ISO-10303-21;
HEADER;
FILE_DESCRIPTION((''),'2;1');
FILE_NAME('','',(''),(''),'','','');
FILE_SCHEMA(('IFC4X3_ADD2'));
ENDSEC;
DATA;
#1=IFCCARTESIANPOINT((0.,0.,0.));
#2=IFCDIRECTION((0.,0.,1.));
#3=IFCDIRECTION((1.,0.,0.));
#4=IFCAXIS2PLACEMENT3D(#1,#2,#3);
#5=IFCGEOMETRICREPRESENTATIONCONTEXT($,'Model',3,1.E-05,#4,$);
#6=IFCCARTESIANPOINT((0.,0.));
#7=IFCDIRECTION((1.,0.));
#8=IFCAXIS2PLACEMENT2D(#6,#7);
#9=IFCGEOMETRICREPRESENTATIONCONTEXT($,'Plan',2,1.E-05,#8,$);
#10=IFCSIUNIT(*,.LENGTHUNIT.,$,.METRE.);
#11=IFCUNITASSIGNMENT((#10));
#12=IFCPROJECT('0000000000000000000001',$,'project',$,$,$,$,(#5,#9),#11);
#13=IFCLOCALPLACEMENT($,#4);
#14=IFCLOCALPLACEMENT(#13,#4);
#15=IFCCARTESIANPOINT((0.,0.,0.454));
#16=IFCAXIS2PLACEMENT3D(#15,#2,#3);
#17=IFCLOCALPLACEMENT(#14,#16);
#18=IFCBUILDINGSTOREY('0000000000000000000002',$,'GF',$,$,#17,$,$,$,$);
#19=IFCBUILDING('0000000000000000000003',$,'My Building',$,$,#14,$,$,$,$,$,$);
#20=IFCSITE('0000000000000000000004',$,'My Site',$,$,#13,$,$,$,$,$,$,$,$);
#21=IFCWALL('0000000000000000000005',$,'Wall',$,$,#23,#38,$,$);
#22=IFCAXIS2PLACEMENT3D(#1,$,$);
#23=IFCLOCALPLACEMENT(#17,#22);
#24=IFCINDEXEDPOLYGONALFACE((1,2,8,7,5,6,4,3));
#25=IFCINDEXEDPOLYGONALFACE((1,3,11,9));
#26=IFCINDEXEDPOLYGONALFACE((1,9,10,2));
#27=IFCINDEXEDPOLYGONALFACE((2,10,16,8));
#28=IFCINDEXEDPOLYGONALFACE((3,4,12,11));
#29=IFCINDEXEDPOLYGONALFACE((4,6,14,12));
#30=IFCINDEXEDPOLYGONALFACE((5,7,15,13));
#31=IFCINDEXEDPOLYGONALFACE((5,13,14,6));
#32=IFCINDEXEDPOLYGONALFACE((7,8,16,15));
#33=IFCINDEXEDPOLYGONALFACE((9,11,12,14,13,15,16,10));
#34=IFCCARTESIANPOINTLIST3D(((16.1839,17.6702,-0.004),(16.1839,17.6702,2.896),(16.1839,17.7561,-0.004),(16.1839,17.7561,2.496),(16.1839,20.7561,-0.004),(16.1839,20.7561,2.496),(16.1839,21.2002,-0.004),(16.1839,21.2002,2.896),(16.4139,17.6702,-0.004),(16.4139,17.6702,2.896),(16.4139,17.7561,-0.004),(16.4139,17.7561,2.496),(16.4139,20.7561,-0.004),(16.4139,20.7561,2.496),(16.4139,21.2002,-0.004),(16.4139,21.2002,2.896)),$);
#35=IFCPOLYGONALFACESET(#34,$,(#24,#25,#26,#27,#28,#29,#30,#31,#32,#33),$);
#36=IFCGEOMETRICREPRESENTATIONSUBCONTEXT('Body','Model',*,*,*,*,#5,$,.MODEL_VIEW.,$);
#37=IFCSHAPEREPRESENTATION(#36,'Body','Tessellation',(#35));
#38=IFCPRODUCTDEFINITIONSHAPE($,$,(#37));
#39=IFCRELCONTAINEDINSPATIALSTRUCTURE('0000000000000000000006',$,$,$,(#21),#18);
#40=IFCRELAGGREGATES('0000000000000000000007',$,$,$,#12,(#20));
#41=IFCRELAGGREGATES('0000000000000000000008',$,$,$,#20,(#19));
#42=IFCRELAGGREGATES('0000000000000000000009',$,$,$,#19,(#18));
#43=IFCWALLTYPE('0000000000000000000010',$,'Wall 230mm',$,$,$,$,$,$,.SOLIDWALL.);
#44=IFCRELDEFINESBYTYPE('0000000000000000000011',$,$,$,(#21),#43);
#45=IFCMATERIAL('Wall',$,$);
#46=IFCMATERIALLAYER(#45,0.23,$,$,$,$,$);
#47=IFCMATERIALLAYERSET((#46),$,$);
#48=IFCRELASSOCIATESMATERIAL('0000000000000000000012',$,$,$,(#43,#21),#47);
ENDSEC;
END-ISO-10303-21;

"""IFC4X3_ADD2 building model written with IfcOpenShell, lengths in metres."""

from ifc_helpers import new_model, si_unit, frame, origin_with_axes, origin_2d_with_axis, place, context, subcontext, project, spatial, line, indexed_curve, outline, extrude, source, transform, mapped, material, layer, layer_set, layer_usage, type_object, element, save


model = new_model("IFC4X3_ADD2")

# Units and contexts
model_context = context("Model", 3, precision=1e-05, world=origin_with_axes())
plan_context = context("Plan", 2, precision=1e-05, world=origin_2d_with_axis())
body_context = subcontext(model_context, "Body", "Model", "MODEL_VIEW")
ifc_project = project(units=[si_unit("LENGTHUNIT", "METRE")], contexts=[model_context, plan_context])

# Site, building, storey
site_placement = place(None, origin_with_axes())
site = spatial("IfcSite", under=ifc_project, at=site_placement, Name="My Site")
building_placement = place(site_placement, origin_with_axes())
building = spatial("IfcBuilding", under=site, at=building_placement, Name="My Building")
storey_placement = place(building_placement, frame((0.0, 0.0, 0.454), z_axis=(0.0, 0.0, 1.0), x_axis=(1.0, 0.0, 0.0)))
storey = spatial("IfcBuildingStorey", under=building, at=storey_placement, Name="GF")

# Wall, opening
ifc_material_1 = material(Name="Wall")
ifc_layer_1 = layer(ifc_material_1, 0.23)
ifc_layer_set_1 = layer_set([ifc_layer_1])
ifc_layer_usage_1 = layer_usage(ifc_layer_set_1, "AXIS2", "POSITIVE", 0.0)
wall_type = type_object("IfcWallType", Name="Wall 230mm", PredefinedType="SOLIDWALL", material=ifc_layer_set_1)
wall_placement = place(storey_placement, frame((16.4139, 17.6702, -0.004), z_axis=(0.0, 0.0, 1.0), x_axis=(0.000001, 1.0, 0.0)))
wall = element("IfcWall", 1, at=wall_placement, inside=storey, type_object=wall_type, material=ifc_layer_usage_1, Name="Wall", context=body_context, shape_type="SweptSolid", body=[
    extrude(outline(indexed_curve([(0.0, 0.0), (0.0, 0.23), (3.53, 0.23), (3.53, 0.0), (0.0, 0.0)], self_intersect=False)), origin_with_axes(), (0.0, 0.0, 1.0), 2.9),
])
shared_shape = source(origin_with_axes(), body_context, "Body", "SweptSolid", [
    extrude(outline(indexed_curve([(0.0, 0.0), (3.0, 0.0), (3.0, 2.5), (0.0, 2.5)], segments=[line(1, 2, 3, 4, 1)])), frame((0.0, -0.6, 0.0), z_axis=(0.0, -1.0, 0.0), x_axis=(1.0, 0.0, 0.0)), (0.0, 0.0, -1.0), 1.2),
])
opening_placement = place(wall_placement, frame((0.0859, 0.0, 0.0), z_axis=(0.0, 0.0, 1.0), x_axis=(1.0, 0.0, 0.0)))
element("IfcOpeningElement", 2, at=opening_placement, cuts=wall, PredefinedType="OPENING", context=body_context, shape_type="MappedRepresentation", body=[
    mapped(shared_shape, transform((0.0, 0.0, 0.0), x_axis=(1.0, 0.0, 0.0), y_axis=(0.0, 1.0, 0.0), z_axis=(0.0, 0.0, 1.0), scale=1.0)),
])

save(model, "model.ifc")
